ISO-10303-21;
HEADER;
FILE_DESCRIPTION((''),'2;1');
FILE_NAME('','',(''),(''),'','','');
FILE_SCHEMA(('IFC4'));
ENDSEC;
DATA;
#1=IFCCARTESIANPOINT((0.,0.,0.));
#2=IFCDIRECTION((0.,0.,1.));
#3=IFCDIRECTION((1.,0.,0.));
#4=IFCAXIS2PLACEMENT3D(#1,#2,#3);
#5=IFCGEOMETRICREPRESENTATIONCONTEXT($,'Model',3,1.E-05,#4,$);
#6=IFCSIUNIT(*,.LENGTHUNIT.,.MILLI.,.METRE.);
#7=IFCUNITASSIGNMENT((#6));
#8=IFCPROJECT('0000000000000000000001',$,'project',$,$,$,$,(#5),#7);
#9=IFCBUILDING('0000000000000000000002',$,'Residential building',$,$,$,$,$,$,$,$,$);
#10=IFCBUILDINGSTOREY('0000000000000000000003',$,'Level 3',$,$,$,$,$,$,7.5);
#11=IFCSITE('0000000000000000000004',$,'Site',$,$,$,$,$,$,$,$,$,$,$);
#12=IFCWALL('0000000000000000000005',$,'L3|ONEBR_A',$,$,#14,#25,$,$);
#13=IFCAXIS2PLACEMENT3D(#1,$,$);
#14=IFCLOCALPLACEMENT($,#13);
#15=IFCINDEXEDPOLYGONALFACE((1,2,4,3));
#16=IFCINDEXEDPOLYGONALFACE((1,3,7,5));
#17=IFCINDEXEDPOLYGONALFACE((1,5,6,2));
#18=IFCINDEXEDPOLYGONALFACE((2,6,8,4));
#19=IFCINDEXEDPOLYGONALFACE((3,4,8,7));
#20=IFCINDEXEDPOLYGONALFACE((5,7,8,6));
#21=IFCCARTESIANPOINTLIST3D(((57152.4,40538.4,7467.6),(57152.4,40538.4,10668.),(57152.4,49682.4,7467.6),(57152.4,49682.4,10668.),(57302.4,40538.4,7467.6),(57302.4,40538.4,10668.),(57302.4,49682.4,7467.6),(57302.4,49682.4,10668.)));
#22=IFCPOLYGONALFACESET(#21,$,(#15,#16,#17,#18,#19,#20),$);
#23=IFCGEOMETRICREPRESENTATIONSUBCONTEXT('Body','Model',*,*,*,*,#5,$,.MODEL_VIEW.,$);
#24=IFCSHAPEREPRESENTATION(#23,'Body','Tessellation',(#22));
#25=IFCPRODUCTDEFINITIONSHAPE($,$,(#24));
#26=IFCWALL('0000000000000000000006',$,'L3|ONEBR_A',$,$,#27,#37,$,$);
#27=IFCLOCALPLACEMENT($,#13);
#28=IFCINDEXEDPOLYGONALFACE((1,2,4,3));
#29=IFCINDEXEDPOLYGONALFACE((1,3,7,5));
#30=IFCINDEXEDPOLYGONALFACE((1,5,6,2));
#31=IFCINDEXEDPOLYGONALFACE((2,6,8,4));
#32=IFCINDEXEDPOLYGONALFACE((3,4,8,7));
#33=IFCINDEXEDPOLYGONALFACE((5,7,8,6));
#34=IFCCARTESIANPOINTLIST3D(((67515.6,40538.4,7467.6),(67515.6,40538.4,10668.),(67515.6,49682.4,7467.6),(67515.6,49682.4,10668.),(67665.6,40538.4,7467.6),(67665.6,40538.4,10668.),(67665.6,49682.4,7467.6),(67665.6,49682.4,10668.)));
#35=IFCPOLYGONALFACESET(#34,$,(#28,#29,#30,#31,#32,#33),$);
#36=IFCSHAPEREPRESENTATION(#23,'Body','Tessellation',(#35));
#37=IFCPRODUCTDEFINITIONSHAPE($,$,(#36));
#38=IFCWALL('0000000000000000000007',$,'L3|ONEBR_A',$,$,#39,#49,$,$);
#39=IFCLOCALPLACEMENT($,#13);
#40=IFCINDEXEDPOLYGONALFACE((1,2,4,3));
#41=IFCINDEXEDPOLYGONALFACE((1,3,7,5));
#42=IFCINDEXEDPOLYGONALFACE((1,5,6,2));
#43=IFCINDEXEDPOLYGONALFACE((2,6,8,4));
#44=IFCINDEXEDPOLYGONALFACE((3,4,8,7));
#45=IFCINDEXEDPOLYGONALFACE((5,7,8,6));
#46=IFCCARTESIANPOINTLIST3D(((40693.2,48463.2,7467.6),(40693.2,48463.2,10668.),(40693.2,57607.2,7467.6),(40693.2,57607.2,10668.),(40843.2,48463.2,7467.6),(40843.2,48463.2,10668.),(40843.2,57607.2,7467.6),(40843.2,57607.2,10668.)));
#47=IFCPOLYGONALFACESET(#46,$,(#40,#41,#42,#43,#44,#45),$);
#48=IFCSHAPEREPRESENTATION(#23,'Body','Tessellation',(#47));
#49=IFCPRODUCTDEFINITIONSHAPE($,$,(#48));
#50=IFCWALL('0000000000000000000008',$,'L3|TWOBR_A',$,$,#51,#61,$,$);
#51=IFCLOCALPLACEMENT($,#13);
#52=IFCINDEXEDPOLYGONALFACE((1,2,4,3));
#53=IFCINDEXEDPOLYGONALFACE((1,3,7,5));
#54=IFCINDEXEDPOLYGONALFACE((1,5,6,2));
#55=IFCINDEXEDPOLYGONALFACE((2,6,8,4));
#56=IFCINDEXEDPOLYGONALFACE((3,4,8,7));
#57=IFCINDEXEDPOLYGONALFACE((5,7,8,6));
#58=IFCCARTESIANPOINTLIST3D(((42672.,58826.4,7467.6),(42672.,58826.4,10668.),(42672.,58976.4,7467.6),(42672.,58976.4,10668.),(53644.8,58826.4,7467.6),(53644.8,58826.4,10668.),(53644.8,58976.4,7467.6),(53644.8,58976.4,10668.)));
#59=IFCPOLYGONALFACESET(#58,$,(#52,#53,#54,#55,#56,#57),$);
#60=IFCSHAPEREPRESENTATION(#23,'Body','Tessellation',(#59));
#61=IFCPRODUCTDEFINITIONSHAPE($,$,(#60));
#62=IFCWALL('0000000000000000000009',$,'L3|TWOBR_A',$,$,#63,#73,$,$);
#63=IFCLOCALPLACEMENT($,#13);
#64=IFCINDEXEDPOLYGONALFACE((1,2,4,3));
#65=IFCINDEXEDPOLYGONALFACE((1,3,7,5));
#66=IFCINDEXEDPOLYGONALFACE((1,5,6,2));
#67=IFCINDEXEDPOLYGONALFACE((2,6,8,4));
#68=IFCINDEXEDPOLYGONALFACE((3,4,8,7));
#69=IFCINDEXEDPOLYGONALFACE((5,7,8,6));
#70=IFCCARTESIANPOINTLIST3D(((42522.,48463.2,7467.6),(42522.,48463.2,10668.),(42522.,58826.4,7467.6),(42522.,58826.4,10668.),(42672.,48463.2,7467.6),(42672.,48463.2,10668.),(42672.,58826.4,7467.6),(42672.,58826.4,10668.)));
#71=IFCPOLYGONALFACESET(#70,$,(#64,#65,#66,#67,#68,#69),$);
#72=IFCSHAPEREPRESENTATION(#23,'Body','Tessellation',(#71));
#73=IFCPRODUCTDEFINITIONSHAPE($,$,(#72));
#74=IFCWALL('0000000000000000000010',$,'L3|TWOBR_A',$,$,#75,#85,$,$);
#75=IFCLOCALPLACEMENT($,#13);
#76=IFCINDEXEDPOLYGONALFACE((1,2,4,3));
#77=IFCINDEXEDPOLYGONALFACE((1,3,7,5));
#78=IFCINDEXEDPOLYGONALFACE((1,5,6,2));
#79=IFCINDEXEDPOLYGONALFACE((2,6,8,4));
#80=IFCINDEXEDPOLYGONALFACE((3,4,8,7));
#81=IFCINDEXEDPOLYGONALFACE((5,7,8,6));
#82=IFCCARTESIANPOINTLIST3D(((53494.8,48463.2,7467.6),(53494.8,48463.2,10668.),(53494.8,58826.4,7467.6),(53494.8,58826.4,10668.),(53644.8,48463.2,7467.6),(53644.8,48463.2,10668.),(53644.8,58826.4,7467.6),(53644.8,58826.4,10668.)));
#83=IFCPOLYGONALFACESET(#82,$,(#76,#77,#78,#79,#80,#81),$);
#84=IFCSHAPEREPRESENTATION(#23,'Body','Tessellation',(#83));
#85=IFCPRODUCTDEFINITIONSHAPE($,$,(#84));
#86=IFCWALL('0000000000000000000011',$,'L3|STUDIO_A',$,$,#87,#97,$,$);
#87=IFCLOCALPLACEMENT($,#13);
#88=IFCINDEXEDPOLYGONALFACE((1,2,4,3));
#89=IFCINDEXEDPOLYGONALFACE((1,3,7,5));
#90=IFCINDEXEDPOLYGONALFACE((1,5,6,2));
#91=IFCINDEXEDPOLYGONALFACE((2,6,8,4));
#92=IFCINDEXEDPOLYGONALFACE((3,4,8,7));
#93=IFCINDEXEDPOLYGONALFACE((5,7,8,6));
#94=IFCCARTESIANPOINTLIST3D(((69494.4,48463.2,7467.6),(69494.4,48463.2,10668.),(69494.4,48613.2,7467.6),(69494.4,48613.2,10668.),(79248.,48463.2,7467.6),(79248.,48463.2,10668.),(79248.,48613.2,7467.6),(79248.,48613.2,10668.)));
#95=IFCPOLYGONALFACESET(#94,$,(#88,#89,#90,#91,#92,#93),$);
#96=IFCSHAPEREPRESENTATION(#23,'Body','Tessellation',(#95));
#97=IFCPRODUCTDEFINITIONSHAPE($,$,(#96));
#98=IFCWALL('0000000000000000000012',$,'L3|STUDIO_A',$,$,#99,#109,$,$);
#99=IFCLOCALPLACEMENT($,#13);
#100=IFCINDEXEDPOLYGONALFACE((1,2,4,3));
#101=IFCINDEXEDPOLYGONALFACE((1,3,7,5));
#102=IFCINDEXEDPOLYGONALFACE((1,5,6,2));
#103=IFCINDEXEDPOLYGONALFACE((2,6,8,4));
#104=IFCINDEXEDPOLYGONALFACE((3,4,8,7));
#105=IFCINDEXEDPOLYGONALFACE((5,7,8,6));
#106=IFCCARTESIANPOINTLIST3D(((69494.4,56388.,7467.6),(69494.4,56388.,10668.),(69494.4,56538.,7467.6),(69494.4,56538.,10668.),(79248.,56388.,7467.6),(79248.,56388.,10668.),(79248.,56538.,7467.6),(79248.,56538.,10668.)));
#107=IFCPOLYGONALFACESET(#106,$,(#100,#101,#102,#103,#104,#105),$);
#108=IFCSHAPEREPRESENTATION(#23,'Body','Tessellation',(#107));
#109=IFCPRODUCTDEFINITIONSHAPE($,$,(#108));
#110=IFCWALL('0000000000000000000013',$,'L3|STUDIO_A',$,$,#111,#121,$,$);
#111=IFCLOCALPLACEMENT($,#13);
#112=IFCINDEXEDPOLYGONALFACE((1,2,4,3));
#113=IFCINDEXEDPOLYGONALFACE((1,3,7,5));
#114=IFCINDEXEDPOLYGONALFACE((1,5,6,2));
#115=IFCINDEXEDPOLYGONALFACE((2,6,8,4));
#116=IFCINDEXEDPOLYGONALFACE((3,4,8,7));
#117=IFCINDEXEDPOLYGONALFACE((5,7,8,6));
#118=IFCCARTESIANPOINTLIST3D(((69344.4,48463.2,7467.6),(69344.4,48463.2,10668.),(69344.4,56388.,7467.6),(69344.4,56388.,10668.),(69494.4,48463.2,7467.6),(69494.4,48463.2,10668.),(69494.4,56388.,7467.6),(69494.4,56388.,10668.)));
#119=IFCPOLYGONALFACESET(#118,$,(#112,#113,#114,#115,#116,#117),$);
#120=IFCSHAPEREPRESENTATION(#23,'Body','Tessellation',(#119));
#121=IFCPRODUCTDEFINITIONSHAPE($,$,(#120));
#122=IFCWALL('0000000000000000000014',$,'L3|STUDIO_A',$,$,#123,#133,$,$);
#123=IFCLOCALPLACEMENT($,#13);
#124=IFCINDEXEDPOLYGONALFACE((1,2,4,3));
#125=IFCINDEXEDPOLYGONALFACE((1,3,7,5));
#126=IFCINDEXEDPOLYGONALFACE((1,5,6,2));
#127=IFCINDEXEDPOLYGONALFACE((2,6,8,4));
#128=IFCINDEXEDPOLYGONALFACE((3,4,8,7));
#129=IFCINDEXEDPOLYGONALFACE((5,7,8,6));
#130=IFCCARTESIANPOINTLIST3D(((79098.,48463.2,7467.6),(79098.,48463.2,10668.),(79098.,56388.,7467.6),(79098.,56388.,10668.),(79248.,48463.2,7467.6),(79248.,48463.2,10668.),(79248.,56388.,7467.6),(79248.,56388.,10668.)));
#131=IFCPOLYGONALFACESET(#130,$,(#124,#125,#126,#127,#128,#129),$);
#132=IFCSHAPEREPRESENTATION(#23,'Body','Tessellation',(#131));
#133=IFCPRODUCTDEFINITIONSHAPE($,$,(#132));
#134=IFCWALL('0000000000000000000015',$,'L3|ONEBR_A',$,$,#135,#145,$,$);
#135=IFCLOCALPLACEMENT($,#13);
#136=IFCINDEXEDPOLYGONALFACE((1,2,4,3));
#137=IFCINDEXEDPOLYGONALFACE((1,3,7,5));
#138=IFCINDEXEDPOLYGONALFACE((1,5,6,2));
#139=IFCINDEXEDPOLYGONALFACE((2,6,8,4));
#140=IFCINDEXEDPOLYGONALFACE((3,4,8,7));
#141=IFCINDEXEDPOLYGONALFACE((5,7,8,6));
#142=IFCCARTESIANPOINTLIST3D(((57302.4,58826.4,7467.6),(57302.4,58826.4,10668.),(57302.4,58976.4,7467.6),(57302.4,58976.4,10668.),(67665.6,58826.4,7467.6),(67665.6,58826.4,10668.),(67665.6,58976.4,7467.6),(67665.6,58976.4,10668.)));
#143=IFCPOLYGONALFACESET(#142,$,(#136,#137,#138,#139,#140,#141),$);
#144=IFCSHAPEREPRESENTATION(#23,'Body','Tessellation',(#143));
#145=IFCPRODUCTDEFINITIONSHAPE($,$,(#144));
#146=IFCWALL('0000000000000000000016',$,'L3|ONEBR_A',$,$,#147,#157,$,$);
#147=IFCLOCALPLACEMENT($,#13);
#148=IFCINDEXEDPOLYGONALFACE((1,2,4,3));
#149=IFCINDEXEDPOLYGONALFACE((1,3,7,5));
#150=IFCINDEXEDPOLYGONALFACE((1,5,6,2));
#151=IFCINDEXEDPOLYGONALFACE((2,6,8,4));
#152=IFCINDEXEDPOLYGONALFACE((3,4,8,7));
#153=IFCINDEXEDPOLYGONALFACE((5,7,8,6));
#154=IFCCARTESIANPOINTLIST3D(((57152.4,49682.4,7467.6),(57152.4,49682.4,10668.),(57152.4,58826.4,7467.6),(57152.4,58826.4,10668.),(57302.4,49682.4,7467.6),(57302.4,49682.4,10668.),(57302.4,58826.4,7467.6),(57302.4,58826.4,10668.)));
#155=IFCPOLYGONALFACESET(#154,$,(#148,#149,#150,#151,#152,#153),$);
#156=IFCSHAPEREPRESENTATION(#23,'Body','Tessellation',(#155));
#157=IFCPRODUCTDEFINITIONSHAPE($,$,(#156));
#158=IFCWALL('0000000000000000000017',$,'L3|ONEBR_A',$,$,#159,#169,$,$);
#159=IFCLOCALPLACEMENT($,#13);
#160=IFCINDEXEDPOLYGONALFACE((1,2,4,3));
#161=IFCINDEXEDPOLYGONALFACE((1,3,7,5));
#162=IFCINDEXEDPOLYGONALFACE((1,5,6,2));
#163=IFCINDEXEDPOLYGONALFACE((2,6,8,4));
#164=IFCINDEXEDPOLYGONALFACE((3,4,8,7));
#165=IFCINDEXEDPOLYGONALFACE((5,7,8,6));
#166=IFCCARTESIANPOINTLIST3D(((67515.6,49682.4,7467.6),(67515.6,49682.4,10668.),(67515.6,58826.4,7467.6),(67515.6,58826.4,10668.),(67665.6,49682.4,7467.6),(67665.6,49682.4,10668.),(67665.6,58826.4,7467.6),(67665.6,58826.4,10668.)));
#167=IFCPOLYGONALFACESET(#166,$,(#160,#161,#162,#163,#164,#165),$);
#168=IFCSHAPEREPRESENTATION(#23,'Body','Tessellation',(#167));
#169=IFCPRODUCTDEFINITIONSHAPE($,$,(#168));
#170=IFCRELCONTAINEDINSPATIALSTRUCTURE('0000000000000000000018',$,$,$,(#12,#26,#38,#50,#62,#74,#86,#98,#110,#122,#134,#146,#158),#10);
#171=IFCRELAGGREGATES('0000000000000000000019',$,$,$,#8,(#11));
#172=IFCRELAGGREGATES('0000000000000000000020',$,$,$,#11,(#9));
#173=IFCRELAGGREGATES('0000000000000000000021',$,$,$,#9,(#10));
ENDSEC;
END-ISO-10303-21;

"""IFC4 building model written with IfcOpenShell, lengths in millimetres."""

from ifc_helpers import new_model, si_unit, frame, origin_with_axes, place, context, subcontext, project, spatial, indexed_curve, outline, extrude, element, save


model = new_model("IFC4")

# Units and contexts
model_context = context("Model", 3, precision=1e-05, world=origin_with_axes())
body_context = subcontext(model_context, "Body", "Model", "MODEL_VIEW")
ifc_project = project(units=[si_unit("LENGTHUNIT", "METRE", prefix="MILLI")], contexts=[model_context])

# Site, building, storey
site = spatial("IfcSite", under=ifc_project, Name="Site")
building = spatial("IfcBuilding", under=site, Name="Residential building")
storey = spatial("IfcBuildingStorey", under=building, Name="Level 3", Elevation=7.5)

# Walls
for number, where, z_axis, x_axis, name in (
    (1, (57302.4, 40538.4, 7467.6), (0.0, 0.0, 1.0), (0.0, 1.0, 0.0), "L3|ONEBR_A"),
    (2, (67665.6, 40538.4, 7467.6), (0.0, 0.0, 1.0), (0.0, 1.0, 0.0), "L3|ONEBR_A"),
    (3, (40843.2, 48463.2, 7467.6), (0.0, 0.0, 1.0), (0.0, 1.0, 0.0), "L3|ONEBR_A"),
):
    element("IfcWall", number, at=place(None, frame(where, z_axis=z_axis, x_axis=x_axis)), inside=storey, Name=name, context=body_context, shape_type="SweptSolid", body=[
        extrude(outline(indexed_curve([(0.0, 0.0), (0.0, 150.0), (9144.0, 150.0), (9144.0, 0.0), (0.0, 0.0)], self_intersect=False)), origin_with_axes(), (0.0, 0.0, 1.0), 3200.4),
    ])
for number, where, z_axis, x_axis, name in (
    (4, (42672.0, 58826.4, 7467.6), (0.0, 0.0, 1.0), (1.0, 0.0, 0.0), "L3|TWOBR_A"),
):
    element("IfcWall", number, at=place(None, frame(where, z_axis=z_axis, x_axis=x_axis)), inside=storey, Name=name, context=body_context, shape_type="SweptSolid", body=[
        extrude(outline(indexed_curve([(0.0, 0.0), (0.0, 150.0), (10972.8, 150.0), (10972.8, 0.0), (0.0, 0.0)], self_intersect=False)), origin_with_axes(), (0.0, 0.0, 1.0), 3200.4),
    ])
for number, where, z_axis, x_axis, name in (
    (5, (42672.0, 48463.2, 7467.6), (0.0, 0.0, 1.0), (0.0, 1.0, 0.0), "L3|TWOBR_A"),
    (6, (53644.8, 48463.2, 7467.6), (0.0, 0.0, 1.0), (0.0, 1.0, 0.0), "L3|TWOBR_A"),
):
    element("IfcWall", number, at=place(None, frame(where, z_axis=z_axis, x_axis=x_axis)), inside=storey, Name=name, context=body_context, shape_type="SweptSolid", body=[
        extrude(outline(indexed_curve([(0.0, 0.0), (0.0, 150.0), (10363.2, 150.0), (10363.2, 0.0), (0.0, 0.0)], self_intersect=False)), origin_with_axes(), (0.0, 0.0, 1.0), 3200.4),
    ])
for number, where, z_axis, x_axis, name in (
    (7, (69494.4, 48463.2, 7467.6), (0.0, 0.0, 1.0), (1.0, 0.0, 0.0), "L3|STUDIO_A"),
    (8, (69494.4, 56388.0, 7467.6), (0.0, 0.0, 1.0), (1.0, 0.0, 0.0), "L3|STUDIO_A"),
):
    element("IfcWall", number, at=place(None, frame(where, z_axis=z_axis, x_axis=x_axis)), inside=storey, Name=name, context=body_context, shape_type="SweptSolid", body=[
        extrude(outline(indexed_curve([(0.0, 0.0), (0.0, 150.0), (9753.6, 150.0), (9753.6, 0.0), (0.0, 0.0)], self_intersect=False)), origin_with_axes(), (0.0, 0.0, 1.0), 3200.4),
    ])
for number, where, z_axis, x_axis, name in (
    (9, (69494.4, 48463.2, 7467.6), (0.0, 0.0, 1.0), (0.0, 1.0, 0.0), "L3|STUDIO_A"),
    (10, (79248.0, 48463.2, 7467.6), (0.0, 0.0, 1.0), (0.0, 1.0, 0.0), "L3|STUDIO_A"),
):
    element("IfcWall", number, at=place(None, frame(where, z_axis=z_axis, x_axis=x_axis)), inside=storey, Name=name, context=body_context, shape_type="SweptSolid", body=[
        extrude(outline(indexed_curve([(0.0, 0.0), (0.0, 150.0), (7924.8, 150.0), (7924.8, 0.0), (0.0, 0.0)], self_intersect=False)), origin_with_axes(), (0.0, 0.0, 1.0), 3200.4),
    ])
for number, where, z_axis, x_axis, name in (
    (11, (57302.4, 58826.4, 7467.6), (0.0, 0.0, 1.0), (1.0, 0.0, 0.0), "L3|ONEBR_A"),
):
    element("IfcWall", number, at=place(None, frame(where, z_axis=z_axis, x_axis=x_axis)), inside=storey, Name=name, context=body_context, shape_type="SweptSolid", body=[
        extrude(outline(indexed_curve([(0.0, 0.0), (0.0, 150.0), (10363.2, 150.0), (10363.2, 0.0), (0.0, 0.0)], self_intersect=False)), origin_with_axes(), (0.0, 0.0, 1.0), 3200.4),
    ])
for number, where, z_axis, x_axis, name in (
    (12, (57302.4, 49682.4, 7467.6), (0.0, 0.0, 1.0), (0.0, 1.0, 0.0), "L3|ONEBR_A"),
    (13, (67665.6, 49682.4, 7467.6), (0.0, 0.0, 1.0), (0.0, 1.0, 0.0), "L3|ONEBR_A"),
):
    element("IfcWall", number, at=place(None, frame(where, z_axis=z_axis, x_axis=x_axis)), inside=storey, Name=name, context=body_context, shape_type="SweptSolid", body=[
        extrude(outline(indexed_curve([(0.0, 0.0), (0.0, 150.0), (9144.0, 150.0), (9144.0, 0.0), (0.0, 0.0)], self_intersect=False)), origin_with_axes(), (0.0, 0.0, 1.0), 3200.4),
    ])

save(model, "model.ifc")
